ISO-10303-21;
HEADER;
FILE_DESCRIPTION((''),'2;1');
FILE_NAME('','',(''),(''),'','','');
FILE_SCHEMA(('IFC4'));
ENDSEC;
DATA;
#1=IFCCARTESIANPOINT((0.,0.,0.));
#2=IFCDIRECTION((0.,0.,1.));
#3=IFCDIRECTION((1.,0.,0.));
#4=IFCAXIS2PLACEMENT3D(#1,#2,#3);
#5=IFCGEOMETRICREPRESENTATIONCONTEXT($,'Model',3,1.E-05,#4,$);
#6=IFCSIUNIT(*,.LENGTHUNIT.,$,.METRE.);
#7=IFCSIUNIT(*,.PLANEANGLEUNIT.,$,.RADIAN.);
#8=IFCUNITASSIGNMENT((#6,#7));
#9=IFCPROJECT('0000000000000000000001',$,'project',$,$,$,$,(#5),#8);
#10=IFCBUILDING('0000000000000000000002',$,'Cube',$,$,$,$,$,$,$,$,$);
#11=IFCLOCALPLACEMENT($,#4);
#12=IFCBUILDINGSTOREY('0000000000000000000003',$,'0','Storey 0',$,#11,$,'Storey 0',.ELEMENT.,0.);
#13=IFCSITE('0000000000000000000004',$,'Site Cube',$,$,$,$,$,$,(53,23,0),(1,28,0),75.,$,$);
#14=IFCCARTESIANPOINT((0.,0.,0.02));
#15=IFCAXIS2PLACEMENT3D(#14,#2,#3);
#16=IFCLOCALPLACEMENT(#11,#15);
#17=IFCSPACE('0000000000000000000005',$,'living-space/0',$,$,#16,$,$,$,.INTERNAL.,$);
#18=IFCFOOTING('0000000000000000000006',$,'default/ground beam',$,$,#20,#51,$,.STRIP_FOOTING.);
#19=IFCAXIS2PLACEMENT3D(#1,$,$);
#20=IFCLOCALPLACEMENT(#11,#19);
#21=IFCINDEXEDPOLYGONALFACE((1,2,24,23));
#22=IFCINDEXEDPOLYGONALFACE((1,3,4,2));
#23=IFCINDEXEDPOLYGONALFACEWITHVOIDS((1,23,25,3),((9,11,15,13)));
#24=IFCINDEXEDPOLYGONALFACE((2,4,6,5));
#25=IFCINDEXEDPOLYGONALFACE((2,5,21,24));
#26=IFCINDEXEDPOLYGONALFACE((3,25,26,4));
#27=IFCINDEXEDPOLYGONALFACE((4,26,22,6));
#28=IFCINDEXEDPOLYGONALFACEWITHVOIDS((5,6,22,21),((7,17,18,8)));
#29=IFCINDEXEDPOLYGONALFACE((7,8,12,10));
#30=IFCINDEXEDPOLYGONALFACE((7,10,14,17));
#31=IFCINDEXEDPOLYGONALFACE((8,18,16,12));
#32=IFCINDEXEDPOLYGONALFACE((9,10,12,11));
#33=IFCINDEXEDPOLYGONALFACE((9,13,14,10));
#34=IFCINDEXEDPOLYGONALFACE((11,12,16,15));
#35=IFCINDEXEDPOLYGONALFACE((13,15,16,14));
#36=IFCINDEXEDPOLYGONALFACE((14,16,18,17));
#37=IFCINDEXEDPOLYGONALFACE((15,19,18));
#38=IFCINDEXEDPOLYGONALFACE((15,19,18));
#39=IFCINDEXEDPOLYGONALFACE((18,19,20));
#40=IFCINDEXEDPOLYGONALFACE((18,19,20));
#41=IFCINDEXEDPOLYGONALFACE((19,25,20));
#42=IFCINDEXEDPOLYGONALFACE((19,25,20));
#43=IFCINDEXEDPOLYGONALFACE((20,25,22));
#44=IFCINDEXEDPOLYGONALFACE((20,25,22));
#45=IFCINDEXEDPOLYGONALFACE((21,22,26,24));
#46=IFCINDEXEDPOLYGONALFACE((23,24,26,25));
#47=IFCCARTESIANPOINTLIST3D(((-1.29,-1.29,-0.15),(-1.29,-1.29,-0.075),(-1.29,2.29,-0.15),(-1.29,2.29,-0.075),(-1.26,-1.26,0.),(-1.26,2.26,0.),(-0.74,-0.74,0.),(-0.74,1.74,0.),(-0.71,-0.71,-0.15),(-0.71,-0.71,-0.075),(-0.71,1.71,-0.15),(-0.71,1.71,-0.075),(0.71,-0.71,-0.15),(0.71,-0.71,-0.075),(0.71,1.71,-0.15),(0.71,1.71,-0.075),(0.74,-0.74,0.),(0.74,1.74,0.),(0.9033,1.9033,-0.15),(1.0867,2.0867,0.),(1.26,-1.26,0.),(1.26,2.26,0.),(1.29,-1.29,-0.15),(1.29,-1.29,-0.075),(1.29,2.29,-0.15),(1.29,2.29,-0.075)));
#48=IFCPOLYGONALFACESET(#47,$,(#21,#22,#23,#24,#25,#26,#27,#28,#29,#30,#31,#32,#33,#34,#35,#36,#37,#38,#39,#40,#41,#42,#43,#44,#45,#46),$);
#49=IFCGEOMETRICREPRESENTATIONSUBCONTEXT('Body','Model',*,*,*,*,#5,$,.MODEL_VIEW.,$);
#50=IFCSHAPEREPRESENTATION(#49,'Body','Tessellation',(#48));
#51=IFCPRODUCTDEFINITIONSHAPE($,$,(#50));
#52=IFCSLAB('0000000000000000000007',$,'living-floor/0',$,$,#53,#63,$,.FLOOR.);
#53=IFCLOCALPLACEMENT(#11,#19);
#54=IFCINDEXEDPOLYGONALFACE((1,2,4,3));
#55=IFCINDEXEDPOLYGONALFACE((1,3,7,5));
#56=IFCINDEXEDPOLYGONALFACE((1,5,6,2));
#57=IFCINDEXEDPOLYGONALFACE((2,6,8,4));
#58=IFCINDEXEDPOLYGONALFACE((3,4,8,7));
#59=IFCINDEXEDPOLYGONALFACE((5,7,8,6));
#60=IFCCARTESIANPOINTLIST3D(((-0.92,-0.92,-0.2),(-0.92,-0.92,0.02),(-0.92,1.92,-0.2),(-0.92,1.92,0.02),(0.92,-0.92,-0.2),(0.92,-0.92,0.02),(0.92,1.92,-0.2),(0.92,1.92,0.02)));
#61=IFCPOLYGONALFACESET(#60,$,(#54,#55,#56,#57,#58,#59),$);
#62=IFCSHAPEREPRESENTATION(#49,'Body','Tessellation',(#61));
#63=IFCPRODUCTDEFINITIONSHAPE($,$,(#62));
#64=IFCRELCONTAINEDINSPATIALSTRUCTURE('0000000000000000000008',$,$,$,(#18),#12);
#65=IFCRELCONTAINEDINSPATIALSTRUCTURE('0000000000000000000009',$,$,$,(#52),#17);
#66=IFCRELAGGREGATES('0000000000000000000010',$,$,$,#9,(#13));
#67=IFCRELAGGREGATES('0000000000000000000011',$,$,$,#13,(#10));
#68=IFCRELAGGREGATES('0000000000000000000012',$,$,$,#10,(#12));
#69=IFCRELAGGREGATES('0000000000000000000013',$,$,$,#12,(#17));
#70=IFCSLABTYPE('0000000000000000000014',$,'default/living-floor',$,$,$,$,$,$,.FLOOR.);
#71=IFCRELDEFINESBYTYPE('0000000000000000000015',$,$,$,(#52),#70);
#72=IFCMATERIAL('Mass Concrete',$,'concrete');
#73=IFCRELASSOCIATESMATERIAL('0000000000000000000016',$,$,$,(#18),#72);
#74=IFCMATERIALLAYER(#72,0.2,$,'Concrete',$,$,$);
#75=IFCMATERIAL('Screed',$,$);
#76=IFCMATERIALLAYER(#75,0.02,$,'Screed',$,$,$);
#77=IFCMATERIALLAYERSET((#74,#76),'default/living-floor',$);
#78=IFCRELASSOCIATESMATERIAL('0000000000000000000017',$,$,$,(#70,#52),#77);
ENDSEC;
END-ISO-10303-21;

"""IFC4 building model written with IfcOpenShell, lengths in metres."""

from ifc_helpers import new_model, entity, si_unit, frame, origin, origin_with_axes, place, context, subcontext, project, spatial, polyline, outline, extrude, material, layer, layer_set, layer_usage, type_object, element, save


model = new_model("IFC4")

# Units and contexts
model_context = context("Model", 3, precision=1e-05, world=origin_with_axes())
body_context = subcontext(model_context, "Body", "Model", "MODEL_VIEW")
ifc_project = project(units=[si_unit("LENGTHUNIT", "METRE"), si_unit("PLANEANGLEUNIT", "RADIAN")], contexts=[model_context])

# Site, building, storey
site = spatial("IfcSite", under=ifc_project, Name="Site Cube", RefLatitude=(53, 23, 0), RefLongitude=(1, 28, 0), RefElevation=75.0)
building = spatial("IfcBuilding", under=site, Name="Cube")
storey_placement = place(None, origin_with_axes())
storey = spatial("IfcBuildingStorey", under=building, at=storey_placement, Name="0", Description="Storey 0", LongName="Storey 0", CompositionType="ELEMENT", Elevation=0.0)

# Footing
ifc_material_1 = material(Name="Mass Concrete", Category="concrete")
footing_placement = place(storey_placement, origin_with_axes())
axis2_placement3_d = entity("IfcAxis2Placement3D", entity("IfcCartesianPoint", [0.0, 0.0, 0.0]))
element("IfcFooting", 1, at=footing_placement, inside=storey, material=ifc_material_1, Name="default/ground beam", PredefinedType="STRIP_FOOTING", context=body_context, shape_type="AdvancedSweptSolid", body=[
    entity("IfcSurfaceCurveSweptAreaSolid", entity("IfcDerivedProfileDef", "AREA", None, entity("IfcArbitraryClosedProfileDef", "AREA", None, entity("IfcPolyline", [entity("IfcCartesianPoint", [0.0, -0.26]), entity("IfcCartesianPoint", [-0.075, -0.29]), entity("IfcCartesianPoint", [-0.15, -0.29]), entity("IfcCartesianPoint", [-0.15, 0.29]), entity("IfcCartesianPoint", [-0.075, 0.29]), entity("IfcCartesianPoint", [0.0, 0.26]), entity("IfcCartesianPoint", [0.0, -0.26])])), entity("IfcCartesianTransformationOperator2D", None, None, entity("IfcCartesianPoint", [0.0, 0.0]), 1.0)), axis2_placement3_d, entity("IfcPolyline", [entity("IfcCartesianPoint", [1.0, 2.0]), entity("IfcCartesianPoint", [-1.0, 2.0]), entity("IfcCartesianPoint", [-1.0, -1.0]), entity("IfcCartesianPoint", [1.0, -1.0]), entity("IfcCartesianPoint", [1.0, 2.0])]), 0.0, 1.0, entity("IfcPlane", axis2_placement3_d)),
])

# Shared definitions
space_placement = place(storey_placement, frame((0.0, 0.0, 0.02), z_axis=(0.0, 0.0, 1.0), x_axis=(1.0, 0.0, 0.0)))
space = spatial("IfcSpace", under=storey, at=space_placement, Name="living-space/0", PredefinedType="INTERNAL")

# Slab
ifc_layer_1 = layer(ifc_material_1, 0.2, Name="Concrete")
ifc_material_2 = material(Name="Screed")
ifc_layer_2 = layer(ifc_material_2, 0.02, Name="Screed")
ifc_layer_set_1 = layer_set([ifc_layer_1, ifc_layer_2], Name="default/living-floor")
ifc_layer_usage_1 = layer_usage(ifc_layer_set_1, "AXIS3", "POSITIVE", -0.2)
slab_type = type_object("IfcSlabType", Name="default/living-floor", PredefinedType="FLOOR", material=ifc_layer_set_1)
slab_placement = place(space_placement, frame((0.0, 0.0, -0.22), z_axis=(0.0, 0.0, 1.0), x_axis=(1.0, 0.0, 0.0)))
element("IfcSlab", 2, at=slab_placement, inside=space, type_object=slab_type, material=ifc_layer_usage_1, Name="living-floor/0", PredefinedType="FLOOR", context=body_context, shape_type="SweptSolid", body=[
    extrude(outline(polyline([(0.92, -0.92), (0.92, 1.92), (-0.92, 1.92), (-0.92, -0.92), (0.92, -0.92)])), origin(), (0.0, 0.0, 1.0), 0.22),
])

save(model, "model.ifc")
